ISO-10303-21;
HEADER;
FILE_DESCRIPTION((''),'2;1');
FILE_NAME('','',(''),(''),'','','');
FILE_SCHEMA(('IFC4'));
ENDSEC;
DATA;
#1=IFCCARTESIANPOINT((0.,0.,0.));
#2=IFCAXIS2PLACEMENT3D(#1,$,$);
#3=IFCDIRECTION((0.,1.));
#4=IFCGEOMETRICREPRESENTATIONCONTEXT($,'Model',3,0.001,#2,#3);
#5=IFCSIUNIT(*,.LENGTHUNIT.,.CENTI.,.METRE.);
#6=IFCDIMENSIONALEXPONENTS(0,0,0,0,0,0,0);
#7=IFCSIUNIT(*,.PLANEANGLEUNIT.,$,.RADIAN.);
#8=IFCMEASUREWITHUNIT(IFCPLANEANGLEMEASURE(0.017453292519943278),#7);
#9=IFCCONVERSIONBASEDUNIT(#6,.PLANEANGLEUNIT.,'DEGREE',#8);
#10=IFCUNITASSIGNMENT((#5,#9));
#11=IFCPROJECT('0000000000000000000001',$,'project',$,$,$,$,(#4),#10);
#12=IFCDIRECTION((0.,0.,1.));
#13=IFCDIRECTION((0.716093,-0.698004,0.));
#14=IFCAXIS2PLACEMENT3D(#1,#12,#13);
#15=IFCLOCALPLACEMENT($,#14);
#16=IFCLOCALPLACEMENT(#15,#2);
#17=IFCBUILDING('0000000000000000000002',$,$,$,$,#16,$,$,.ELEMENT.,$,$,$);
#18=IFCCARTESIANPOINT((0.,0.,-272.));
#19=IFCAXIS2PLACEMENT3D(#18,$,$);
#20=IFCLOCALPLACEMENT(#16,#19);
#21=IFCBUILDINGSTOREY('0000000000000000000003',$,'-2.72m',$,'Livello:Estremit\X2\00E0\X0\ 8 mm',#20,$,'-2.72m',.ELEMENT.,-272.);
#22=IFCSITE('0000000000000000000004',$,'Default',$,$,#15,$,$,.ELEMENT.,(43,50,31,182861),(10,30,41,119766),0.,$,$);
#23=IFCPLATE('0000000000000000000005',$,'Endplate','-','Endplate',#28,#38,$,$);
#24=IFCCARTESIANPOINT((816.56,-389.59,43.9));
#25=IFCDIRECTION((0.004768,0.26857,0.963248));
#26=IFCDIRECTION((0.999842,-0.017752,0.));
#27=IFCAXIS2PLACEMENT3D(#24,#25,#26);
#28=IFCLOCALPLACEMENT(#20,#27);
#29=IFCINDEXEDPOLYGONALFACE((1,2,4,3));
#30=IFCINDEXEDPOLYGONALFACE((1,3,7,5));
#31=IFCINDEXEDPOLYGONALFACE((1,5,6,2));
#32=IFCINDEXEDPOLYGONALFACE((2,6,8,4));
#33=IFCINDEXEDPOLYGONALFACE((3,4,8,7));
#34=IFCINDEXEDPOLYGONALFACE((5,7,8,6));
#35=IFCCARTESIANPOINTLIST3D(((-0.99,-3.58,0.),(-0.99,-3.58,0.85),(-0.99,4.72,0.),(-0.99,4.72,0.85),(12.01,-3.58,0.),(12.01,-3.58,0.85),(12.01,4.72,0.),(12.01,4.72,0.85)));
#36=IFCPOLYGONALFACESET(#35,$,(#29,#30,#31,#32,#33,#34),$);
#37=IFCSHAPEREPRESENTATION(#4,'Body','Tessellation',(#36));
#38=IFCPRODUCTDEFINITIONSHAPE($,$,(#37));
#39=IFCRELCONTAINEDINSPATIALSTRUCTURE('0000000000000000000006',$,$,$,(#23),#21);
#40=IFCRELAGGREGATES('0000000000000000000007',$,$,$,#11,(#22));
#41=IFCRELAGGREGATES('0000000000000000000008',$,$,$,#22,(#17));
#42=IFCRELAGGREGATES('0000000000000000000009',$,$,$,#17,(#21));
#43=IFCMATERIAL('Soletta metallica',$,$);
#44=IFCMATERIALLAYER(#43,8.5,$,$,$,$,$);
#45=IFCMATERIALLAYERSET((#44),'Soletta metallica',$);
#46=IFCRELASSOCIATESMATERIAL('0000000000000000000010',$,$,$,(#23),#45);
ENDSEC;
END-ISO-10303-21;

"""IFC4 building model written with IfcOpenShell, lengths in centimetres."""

from ifc_helpers import new_model, entity, si_unit, converted_unit, direction, frame, origin, origin_with_axes, place, context, project, spatial, polyline, outline, extrude, material, layer, layer_set, element, save


model = new_model("IFC4")

# Units and contexts
model_context = context("Model", 3, precision=0.001, world=origin(), true_north=direction((0.0, 1.0)))
ifc_project = project(units=[si_unit("LENGTHUNIT", "METRE", prefix="CENTI"), converted_unit("PLANEANGLEUNIT", "DEGREE", entity("IfcPlaneAngleMeasure", 0.017453292519943278), si_unit("PLANEANGLEUNIT", "RADIAN"), dimensions=[0, 0, 0, 0, 0, 0, 0])], contexts=[model_context])

# Site, building, storey
site_placement = place(None, frame((0.0, 0.0, 0.0), z_axis=(0.0, 0.0, 1.0), x_axis=(0.716093, -0.698004, 0.0)))
site = spatial("IfcSite", under=ifc_project, at=site_placement, Name="Default", CompositionType="ELEMENT", RefLatitude=(43, 50, 31, 182861), RefLongitude=(10, 30, 41, 119766), RefElevation=0.0)
building_placement = place(site_placement, origin())
building = spatial("IfcBuilding", under=site, at=building_placement, CompositionType="ELEMENT")
storey_placement = place(building_placement, frame((0.0, 0.0, -272.0)))
storey = spatial("IfcBuildingStorey", under=building, at=storey_placement, Name="-2.72m", ObjectType="Livello:Estremità 8 mm", LongName="-2.72m", CompositionType="ELEMENT", Elevation=-272.0)

# Plate
ifc_material = material(Name="Soletta metallica")
ifc_layer_1 = layer(ifc_material, 8.5)
ifc_layer_set_1 = layer_set([ifc_layer_1], Name="Soletta metallica")
plate_1_placement = place(storey_placement, frame((816.56, -389.59, 43.9), z_axis=(0.004768, 0.26857, 0.963248), x_axis=(0.999842, -0.017752, 0.0)))
element("IfcPlate", 1, at=plate_1_placement, inside=storey, material=ifc_layer_set_1, Name="Endplate", Description="-", ObjectType="Endplate", context=model_context, shape_type="SweptSolid", body=[
    extrude(outline(polyline([(-0.99, -3.58), (12.01, -3.58), (12.01, 4.72), (-0.99, 4.72), (-0.99, -3.58)])), origin_with_axes(), (0.0, 0.0, 1.0), 0.85),
])

save(model, "model.ifc")
